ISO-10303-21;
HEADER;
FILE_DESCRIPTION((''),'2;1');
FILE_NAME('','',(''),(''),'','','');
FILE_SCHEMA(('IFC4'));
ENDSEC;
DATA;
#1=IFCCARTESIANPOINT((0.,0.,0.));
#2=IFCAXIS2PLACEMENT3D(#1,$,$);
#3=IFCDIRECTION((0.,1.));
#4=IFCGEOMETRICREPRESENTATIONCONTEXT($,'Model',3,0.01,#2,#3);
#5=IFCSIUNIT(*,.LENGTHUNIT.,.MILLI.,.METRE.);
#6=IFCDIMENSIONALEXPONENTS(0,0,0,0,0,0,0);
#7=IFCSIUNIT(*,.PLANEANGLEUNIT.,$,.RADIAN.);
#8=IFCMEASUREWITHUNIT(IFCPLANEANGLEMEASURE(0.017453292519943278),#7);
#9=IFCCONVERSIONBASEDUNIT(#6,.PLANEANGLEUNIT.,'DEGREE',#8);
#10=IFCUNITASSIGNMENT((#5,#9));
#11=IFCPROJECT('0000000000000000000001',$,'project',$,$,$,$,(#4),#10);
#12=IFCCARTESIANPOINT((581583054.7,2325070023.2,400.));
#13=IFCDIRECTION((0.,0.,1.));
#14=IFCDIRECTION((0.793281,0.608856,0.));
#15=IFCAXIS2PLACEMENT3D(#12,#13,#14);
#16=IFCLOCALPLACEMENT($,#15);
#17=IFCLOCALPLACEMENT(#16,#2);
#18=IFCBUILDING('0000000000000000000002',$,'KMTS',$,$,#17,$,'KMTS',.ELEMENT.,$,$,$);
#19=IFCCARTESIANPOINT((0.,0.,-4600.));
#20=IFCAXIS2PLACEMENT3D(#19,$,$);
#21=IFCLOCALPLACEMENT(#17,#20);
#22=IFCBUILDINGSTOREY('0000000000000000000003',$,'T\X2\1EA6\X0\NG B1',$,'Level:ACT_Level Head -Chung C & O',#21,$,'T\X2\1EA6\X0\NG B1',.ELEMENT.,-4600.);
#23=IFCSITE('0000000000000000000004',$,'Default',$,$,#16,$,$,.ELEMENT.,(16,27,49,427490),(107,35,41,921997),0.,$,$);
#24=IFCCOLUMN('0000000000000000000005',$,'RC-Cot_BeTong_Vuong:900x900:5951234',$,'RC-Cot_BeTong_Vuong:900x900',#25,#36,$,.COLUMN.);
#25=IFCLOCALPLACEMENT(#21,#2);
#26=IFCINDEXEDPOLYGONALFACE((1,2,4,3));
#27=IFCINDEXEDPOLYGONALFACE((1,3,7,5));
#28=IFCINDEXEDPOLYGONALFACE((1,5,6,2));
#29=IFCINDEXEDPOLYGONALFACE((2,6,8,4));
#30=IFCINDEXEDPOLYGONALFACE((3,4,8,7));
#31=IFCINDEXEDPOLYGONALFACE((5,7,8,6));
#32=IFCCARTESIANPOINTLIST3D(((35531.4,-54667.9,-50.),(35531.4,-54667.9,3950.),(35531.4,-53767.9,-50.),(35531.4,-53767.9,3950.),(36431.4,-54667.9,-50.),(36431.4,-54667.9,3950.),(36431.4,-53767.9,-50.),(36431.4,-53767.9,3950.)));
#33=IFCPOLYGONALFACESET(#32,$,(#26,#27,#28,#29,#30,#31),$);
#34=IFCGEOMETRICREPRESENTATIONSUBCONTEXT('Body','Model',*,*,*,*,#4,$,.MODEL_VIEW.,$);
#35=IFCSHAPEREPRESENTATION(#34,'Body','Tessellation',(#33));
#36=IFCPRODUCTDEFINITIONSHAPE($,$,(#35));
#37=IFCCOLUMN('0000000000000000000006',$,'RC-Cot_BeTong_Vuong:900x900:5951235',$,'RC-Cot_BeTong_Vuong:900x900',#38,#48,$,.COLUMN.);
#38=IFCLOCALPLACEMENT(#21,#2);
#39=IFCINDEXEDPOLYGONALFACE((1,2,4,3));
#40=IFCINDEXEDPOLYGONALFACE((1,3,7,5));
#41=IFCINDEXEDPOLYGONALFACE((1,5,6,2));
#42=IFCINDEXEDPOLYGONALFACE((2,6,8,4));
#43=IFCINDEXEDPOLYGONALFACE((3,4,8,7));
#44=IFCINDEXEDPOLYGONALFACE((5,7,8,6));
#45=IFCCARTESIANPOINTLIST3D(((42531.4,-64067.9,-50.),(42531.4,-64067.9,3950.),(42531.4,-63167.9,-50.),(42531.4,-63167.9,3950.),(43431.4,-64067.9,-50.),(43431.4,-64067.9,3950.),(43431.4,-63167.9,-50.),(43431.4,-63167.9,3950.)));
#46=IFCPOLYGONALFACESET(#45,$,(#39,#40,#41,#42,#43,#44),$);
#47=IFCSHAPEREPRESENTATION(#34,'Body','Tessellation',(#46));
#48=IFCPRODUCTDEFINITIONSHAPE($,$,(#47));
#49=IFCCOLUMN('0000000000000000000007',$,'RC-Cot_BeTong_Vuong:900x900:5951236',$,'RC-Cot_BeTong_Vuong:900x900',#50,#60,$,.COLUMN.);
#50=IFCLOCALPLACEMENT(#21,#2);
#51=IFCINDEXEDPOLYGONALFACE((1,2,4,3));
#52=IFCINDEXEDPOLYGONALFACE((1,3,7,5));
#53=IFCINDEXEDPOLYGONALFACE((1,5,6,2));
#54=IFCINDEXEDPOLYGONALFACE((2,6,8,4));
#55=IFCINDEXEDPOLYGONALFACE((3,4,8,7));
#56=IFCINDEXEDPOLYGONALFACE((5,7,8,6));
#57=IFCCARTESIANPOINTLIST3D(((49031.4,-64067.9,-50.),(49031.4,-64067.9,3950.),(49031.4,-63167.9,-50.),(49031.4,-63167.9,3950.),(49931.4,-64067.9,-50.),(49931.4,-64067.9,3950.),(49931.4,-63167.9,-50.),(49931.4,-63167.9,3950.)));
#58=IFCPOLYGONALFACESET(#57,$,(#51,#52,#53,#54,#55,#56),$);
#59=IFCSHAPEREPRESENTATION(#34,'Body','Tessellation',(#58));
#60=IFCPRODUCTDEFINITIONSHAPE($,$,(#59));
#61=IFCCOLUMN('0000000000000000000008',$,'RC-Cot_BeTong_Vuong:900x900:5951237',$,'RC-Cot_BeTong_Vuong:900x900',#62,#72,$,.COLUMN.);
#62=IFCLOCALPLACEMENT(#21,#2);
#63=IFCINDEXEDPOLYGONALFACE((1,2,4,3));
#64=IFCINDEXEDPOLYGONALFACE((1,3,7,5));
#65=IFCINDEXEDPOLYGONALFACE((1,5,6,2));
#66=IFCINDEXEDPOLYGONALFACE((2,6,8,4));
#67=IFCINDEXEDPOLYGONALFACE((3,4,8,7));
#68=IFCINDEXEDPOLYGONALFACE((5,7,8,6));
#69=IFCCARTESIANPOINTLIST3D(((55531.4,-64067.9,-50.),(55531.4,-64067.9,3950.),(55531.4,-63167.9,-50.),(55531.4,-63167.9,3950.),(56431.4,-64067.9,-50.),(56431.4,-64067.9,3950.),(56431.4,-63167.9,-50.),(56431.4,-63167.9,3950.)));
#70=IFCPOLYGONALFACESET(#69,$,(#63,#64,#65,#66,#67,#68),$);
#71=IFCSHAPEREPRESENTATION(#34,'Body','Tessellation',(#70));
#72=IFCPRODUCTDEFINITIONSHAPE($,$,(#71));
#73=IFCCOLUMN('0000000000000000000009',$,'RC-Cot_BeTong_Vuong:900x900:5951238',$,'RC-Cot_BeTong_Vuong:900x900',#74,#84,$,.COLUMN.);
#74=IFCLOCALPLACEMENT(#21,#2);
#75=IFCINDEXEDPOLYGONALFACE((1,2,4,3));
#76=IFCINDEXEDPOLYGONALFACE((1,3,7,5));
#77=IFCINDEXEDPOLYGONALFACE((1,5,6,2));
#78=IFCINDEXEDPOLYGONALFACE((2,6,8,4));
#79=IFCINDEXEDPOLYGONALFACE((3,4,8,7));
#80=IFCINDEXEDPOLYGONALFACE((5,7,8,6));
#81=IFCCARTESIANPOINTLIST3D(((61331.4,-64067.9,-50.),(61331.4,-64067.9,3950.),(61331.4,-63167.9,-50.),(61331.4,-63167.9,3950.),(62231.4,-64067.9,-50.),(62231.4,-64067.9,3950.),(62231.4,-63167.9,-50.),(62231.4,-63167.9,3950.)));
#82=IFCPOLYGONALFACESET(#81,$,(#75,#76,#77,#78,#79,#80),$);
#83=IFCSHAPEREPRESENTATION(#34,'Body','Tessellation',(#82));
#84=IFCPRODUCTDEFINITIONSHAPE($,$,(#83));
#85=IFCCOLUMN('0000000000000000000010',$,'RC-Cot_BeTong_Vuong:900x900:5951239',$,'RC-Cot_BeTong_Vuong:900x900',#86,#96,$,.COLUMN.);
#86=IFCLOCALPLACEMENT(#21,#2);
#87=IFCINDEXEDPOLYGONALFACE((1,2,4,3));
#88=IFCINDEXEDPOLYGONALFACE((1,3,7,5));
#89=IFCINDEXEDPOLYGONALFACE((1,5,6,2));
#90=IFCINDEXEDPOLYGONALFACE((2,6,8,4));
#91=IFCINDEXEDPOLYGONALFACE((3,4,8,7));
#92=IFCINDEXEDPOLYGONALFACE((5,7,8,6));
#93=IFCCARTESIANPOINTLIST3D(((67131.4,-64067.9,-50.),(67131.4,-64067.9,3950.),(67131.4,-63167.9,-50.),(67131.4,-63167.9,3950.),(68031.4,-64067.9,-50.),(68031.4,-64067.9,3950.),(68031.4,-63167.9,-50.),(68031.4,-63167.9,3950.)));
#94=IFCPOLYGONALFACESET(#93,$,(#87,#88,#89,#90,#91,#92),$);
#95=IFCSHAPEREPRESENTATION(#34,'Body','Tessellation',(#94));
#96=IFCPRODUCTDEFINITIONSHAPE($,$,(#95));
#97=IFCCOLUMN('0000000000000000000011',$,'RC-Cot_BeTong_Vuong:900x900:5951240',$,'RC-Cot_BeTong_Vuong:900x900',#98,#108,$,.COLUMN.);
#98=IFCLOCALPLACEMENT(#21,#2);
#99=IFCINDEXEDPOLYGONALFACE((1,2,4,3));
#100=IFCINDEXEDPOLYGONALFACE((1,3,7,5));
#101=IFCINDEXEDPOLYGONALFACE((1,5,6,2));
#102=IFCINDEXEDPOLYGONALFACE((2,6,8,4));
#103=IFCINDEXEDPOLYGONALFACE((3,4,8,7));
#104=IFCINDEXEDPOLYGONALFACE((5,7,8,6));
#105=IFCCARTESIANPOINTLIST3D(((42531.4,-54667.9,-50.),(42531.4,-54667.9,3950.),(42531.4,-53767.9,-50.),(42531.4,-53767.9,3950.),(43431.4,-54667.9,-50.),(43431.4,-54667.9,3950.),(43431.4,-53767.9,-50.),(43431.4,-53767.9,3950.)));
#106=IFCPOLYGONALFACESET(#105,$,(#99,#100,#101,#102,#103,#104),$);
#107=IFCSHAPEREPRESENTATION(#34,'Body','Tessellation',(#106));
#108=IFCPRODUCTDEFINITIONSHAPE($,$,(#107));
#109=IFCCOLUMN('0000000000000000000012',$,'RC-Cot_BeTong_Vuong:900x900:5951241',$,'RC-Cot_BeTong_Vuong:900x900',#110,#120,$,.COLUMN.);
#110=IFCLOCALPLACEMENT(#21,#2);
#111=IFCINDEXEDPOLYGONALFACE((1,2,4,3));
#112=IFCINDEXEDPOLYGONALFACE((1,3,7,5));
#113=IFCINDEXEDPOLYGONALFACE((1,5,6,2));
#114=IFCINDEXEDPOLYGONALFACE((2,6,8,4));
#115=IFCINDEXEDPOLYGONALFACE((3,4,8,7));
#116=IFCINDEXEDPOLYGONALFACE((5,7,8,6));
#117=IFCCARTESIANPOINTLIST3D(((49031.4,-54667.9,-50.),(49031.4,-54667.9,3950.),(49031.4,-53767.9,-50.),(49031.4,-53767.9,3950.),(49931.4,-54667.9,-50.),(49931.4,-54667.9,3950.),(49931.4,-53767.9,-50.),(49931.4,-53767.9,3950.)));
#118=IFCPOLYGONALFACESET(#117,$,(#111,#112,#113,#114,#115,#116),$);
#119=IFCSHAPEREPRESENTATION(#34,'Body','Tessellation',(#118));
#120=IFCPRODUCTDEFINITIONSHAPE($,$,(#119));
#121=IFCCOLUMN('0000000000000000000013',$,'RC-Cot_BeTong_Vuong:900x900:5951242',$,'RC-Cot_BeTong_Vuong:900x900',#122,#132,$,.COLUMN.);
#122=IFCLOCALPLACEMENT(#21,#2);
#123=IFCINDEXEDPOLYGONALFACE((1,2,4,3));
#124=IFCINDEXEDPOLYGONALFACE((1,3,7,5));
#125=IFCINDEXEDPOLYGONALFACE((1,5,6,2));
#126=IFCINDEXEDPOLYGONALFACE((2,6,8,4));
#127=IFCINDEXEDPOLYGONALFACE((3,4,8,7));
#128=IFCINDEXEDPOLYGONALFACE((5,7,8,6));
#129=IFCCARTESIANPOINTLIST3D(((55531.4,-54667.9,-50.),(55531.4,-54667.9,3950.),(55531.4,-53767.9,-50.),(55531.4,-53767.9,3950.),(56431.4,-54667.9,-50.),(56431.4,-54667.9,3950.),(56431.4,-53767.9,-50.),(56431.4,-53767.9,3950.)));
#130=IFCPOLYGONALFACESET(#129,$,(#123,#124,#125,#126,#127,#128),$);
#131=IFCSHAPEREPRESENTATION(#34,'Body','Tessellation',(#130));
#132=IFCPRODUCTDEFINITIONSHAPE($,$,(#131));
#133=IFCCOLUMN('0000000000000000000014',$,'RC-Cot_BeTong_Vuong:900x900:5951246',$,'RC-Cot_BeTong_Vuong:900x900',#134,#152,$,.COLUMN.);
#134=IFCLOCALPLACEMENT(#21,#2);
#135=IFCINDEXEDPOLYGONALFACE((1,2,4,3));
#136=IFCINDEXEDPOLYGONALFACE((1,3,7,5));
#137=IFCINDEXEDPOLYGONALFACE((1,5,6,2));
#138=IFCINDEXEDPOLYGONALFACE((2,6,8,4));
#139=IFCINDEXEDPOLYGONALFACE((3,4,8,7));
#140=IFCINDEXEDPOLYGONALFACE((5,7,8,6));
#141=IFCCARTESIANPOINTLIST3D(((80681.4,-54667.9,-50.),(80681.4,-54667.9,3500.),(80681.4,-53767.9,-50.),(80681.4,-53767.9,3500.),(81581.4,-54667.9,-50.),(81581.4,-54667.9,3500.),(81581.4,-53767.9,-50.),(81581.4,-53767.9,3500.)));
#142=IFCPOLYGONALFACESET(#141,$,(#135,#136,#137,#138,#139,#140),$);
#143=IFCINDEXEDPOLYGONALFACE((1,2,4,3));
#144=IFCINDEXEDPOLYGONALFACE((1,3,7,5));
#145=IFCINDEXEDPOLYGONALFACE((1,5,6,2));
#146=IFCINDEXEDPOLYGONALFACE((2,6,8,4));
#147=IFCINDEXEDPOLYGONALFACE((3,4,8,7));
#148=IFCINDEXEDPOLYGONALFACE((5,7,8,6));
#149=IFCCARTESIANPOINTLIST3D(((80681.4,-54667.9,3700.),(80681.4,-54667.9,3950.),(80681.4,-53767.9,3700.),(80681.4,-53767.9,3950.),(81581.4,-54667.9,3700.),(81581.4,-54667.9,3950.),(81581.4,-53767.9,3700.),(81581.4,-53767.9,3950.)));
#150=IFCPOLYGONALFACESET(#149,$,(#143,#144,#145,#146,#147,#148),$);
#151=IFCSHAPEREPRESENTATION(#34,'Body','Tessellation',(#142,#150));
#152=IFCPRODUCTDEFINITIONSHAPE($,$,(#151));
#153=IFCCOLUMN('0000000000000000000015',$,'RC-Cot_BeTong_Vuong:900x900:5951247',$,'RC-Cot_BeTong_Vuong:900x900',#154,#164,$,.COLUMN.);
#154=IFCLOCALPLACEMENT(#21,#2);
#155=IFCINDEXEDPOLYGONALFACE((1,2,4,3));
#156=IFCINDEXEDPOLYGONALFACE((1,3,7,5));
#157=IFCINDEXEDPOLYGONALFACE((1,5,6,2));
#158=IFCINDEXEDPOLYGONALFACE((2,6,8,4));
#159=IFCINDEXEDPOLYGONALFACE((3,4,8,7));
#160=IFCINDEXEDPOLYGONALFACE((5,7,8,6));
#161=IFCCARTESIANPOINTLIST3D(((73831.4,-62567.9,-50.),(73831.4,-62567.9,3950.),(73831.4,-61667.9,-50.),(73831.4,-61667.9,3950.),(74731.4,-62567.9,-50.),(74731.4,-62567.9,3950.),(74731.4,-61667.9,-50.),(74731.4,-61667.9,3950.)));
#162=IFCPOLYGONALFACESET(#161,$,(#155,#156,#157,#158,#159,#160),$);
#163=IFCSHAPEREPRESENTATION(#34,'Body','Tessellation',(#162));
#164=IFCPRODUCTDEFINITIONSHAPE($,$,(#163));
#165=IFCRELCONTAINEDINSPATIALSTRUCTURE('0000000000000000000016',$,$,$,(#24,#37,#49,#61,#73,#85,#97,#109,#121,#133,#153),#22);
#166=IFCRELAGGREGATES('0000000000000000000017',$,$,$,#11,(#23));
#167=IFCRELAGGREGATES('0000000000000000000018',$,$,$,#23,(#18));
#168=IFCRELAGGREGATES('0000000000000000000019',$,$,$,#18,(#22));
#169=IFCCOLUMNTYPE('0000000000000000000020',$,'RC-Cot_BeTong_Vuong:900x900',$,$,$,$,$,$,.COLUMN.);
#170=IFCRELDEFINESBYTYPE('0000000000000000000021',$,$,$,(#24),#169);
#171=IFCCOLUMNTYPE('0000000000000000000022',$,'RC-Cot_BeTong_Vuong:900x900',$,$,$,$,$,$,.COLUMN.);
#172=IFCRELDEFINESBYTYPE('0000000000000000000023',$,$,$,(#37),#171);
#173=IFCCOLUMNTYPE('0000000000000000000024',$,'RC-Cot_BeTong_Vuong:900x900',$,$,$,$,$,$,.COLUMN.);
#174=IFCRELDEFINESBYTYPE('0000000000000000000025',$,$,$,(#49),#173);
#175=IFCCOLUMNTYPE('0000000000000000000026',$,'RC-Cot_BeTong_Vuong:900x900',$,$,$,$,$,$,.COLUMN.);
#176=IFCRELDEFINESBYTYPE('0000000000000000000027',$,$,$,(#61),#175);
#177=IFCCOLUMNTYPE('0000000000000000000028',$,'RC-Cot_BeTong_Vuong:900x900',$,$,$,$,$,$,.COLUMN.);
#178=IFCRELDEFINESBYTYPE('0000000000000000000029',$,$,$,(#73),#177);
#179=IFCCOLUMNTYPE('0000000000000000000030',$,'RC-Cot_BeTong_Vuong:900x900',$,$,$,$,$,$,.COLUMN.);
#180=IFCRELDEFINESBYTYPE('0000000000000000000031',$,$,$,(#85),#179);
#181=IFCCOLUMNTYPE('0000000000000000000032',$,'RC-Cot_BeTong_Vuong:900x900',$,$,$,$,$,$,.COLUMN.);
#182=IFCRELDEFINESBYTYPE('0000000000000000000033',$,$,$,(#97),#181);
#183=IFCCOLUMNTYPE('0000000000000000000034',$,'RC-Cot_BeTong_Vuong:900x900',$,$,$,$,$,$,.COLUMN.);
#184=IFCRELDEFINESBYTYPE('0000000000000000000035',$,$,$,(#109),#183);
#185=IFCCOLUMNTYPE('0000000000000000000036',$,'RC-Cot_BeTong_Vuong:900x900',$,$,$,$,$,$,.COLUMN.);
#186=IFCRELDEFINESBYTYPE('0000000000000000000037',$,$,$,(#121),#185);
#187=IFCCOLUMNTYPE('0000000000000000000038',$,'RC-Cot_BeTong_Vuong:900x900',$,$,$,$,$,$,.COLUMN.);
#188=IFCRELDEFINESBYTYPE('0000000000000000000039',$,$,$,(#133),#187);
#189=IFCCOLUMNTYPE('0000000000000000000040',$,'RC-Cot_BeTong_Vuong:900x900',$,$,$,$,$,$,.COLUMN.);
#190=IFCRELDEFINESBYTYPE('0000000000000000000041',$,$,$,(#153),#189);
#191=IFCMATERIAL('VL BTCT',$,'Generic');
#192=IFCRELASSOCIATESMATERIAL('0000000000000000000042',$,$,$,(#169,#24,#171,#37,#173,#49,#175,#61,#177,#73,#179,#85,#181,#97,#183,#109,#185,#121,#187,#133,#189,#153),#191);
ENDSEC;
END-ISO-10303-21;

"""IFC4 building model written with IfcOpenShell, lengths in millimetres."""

from ifc_helpers import new_model, entity, si_unit, converted_unit, direction, frame, origin, place, context, subcontext, project, spatial, indexed_curve, outline, extrude, source, transform, mapped, material, type_object, type_shapes, element, save


model = new_model("IFC4")

# Units and contexts
model_context = context("Model", 3, precision=0.01, world=origin(), true_north=direction((0.0, 1.0)))
body_context = subcontext(model_context, "Body", "Model", "MODEL_VIEW")
ifc_project = project(units=[si_unit("LENGTHUNIT", "METRE", prefix="MILLI"), converted_unit("PLANEANGLEUNIT", "DEGREE", entity("IfcPlaneAngleMeasure", 0.017453292519943278), si_unit("PLANEANGLEUNIT", "RADIAN"), dimensions=[0, 0, 0, 0, 0, 0, 0])], contexts=[model_context])

# Site, building, storey
site_placement = place(None, frame((581583054.7, 2325070023.2, 400.0), z_axis=(0.0, 0.0, 1.0), x_axis=(0.793281, 0.608856, 0.0)))
site = spatial("IfcSite", under=ifc_project, at=site_placement, Name="Default", CompositionType="ELEMENT", RefLatitude=(16, 27, 49, 427490), RefLongitude=(107, 35, 41, 921997), RefElevation=0.0)
building_placement = place(site_placement, origin())
building = spatial("IfcBuilding", under=site, at=building_placement, Name="KMTS", LongName="KMTS", CompositionType="ELEMENT")
storey_placement = place(building_placement, frame((0.0, 0.0, -4600.0)))
storey = spatial("IfcBuildingStorey", under=building, at=storey_placement, Name="TẦNG B1", ObjectType="Level:ACT_Level Head -Chung C & O", LongName="TẦNG B1", CompositionType="ELEMENT", Elevation=-4600.0)

# Columns
ifc_material = material(Name="VL BTCT", Category="Generic")
column_type_1 = type_object("IfcColumnType", Name="RC-Cot_BeTong_Vuong:900x900", PredefinedType="COLUMN", material=ifc_material)
shared_shape_1 = source(origin(), body_context, "Body", "SweptSolid", [
    extrude(outline(indexed_curve([(-450.0, -450.0), (450.0, -450.0), (450.0, 450.0), (-450.0, 450.0), (-450.0, -450.0)], self_intersect=False)), frame((35981.4, -54217.9, -4650.0), z_axis=(0.0, 0.0, 1.0), x_axis=(-1.0, 0.0, 0.0)), (0.0, 0.0, 1.0), 4000.0),
])
type_shapes(column_type_1, [shared_shape_1])
column_1_placement = place(storey_placement, frame((0.0, 0.0, 4600.0)))
element("IfcColumn", 1, at=column_1_placement, inside=storey, type_object=column_type_1, material=ifc_material, Name="RC-Cot_BeTong_Vuong:900x900:5951234", ObjectType="RC-Cot_BeTong_Vuong:900x900", PredefinedType="COLUMN", context=body_context, shape_type="MappedRepresentation", body=[
    mapped(shared_shape_1, transform((0.0, 0.0, 0.0), scale=1.0)),
])
column_type_2 = type_object("IfcColumnType", Name="RC-Cot_BeTong_Vuong:900x900", PredefinedType="COLUMN", material=ifc_material)
shared_shape_2 = source(origin(), body_context, "Body", "SweptSolid", [
    extrude(outline(indexed_curve([(-450.0, -450.0), (450.0, -450.0), (450.0, 450.0), (-450.0, 450.0), (-450.0, -450.0)], self_intersect=False)), frame((42981.4, -63617.9, -4650.0), z_axis=(0.0, 0.0, 1.0), x_axis=(-1.0, 0.0, 0.0)), (0.0, 0.0, 1.0), 4000.0),
])
type_shapes(column_type_2, [shared_shape_2])
column_2_placement = place(storey_placement, frame((0.0, 0.0, 4600.0)))
element("IfcColumn", 2, at=column_2_placement, inside=storey, type_object=column_type_2, material=ifc_material, Name="RC-Cot_BeTong_Vuong:900x900:5951235", ObjectType="RC-Cot_BeTong_Vuong:900x900", PredefinedType="COLUMN", context=body_context, shape_type="MappedRepresentation", body=[
    mapped(shared_shape_2, transform((0.0, 0.0, 0.0), scale=1.0)),
])
column_type_3 = type_object("IfcColumnType", Name="RC-Cot_BeTong_Vuong:900x900", PredefinedType="COLUMN", material=ifc_material)
shared_shape_3 = source(origin(), body_context, "Body", "SweptSolid", [
    extrude(outline(indexed_curve([(-450.0, -450.0), (450.0, -450.0), (450.0, 450.0), (-450.0, 450.0), (-450.0, -450.0)], self_intersect=False)), frame((49481.4, -63617.9, -4650.0), z_axis=(0.0, 0.0, 1.0), x_axis=(-1.0, 0.0, 0.0)), (0.0, 0.0, 1.0), 4000.0),
])
type_shapes(column_type_3, [shared_shape_3])
column_3_placement = place(storey_placement, frame((0.0, 0.0, 4600.0)))
element("IfcColumn", 3, at=column_3_placement, inside=storey, type_object=column_type_3, material=ifc_material, Name="RC-Cot_BeTong_Vuong:900x900:5951236", ObjectType="RC-Cot_BeTong_Vuong:900x900", PredefinedType="COLUMN", context=body_context, shape_type="MappedRepresentation", body=[
    mapped(shared_shape_3, transform((0.0, 0.0, 0.0), scale=1.0)),
])
column_type_4 = type_object("IfcColumnType", Name="RC-Cot_BeTong_Vuong:900x900", PredefinedType="COLUMN", material=ifc_material)
shared_shape_4 = source(origin(), body_context, "Body", "SweptSolid", [
    extrude(outline(indexed_curve([(-450.0, -450.0), (450.0, -450.0), (450.0, 450.0), (-450.0, 450.0), (-450.0, -450.0)], self_intersect=False)), frame((55981.4, -63617.9, -4650.0), z_axis=(0.0, 0.0, 1.0), x_axis=(-1.0, 0.0, 0.0)), (0.0, 0.0, 1.0), 4000.0),
])
type_shapes(column_type_4, [shared_shape_4])
column_4_placement = place(storey_placement, frame((0.0, 0.0, 4600.0)))
element("IfcColumn", 4, at=column_4_placement, inside=storey, type_object=column_type_4, material=ifc_material, Name="RC-Cot_BeTong_Vuong:900x900:5951237", ObjectType="RC-Cot_BeTong_Vuong:900x900", PredefinedType="COLUMN", context=body_context, shape_type="MappedRepresentation", body=[
    mapped(shared_shape_4, transform((0.0, 0.0, 0.0), scale=1.0)),
])
column_type_5 = type_object("IfcColumnType", Name="RC-Cot_BeTong_Vuong:900x900", PredefinedType="COLUMN", material=ifc_material)
shared_shape_5 = source(origin(), body_context, "Body", "SweptSolid", [
    extrude(outline(indexed_curve([(-450.0, -450.0), (450.0, -450.0), (450.0, 450.0), (-450.0, 450.0), (-450.0, -450.0)], self_intersect=False)), frame((61781.4, -63617.9, -4650.0), z_axis=(0.0, 0.0, 1.0), x_axis=(-1.0, 0.0, 0.0)), (0.0, 0.0, 1.0), 4000.0),
])
type_shapes(column_type_5, [shared_shape_5])
column_5_placement = place(storey_placement, frame((0.0, 0.0, 4600.0)))
element("IfcColumn", 5, at=column_5_placement, inside=storey, type_object=column_type_5, material=ifc_material, Name="RC-Cot_BeTong_Vuong:900x900:5951238", ObjectType="RC-Cot_BeTong_Vuong:900x900", PredefinedType="COLUMN", context=body_context, shape_type="MappedRepresentation", body=[
    mapped(shared_shape_5, transform((0.0, 0.0, 0.0), scale=1.0)),
])
column_type_6 = type_object("IfcColumnType", Name="RC-Cot_BeTong_Vuong:900x900", PredefinedType="COLUMN", material=ifc_material)
shared_shape_6 = source(origin(), body_context, "Body", "SweptSolid", [
    extrude(outline(indexed_curve([(-450.0, -450.0), (450.0, -450.0), (450.0, 450.0), (-450.0, 450.0), (-450.0, -450.0)], self_intersect=False)), frame((67581.4, -63617.9, -4650.0), z_axis=(0.0, 0.0, 1.0), x_axis=(-1.0, 0.0, 0.0)), (0.0, 0.0, 1.0), 4000.0),
])
type_shapes(column_type_6, [shared_shape_6])
column_6_placement = place(storey_placement, frame((0.0, 0.0, 4600.0)))
element("IfcColumn", 6, at=column_6_placement, inside=storey, type_object=column_type_6, material=ifc_material, Name="RC-Cot_BeTong_Vuong:900x900:5951239", ObjectType="RC-Cot_BeTong_Vuong:900x900", PredefinedType="COLUMN", context=body_context, shape_type="MappedRepresentation", body=[
    mapped(shared_shape_6, transform((0.0, 0.0, 0.0), scale=1.0)),
])
column_type_7 = type_object("IfcColumnType", Name="RC-Cot_BeTong_Vuong:900x900", PredefinedType="COLUMN", material=ifc_material)
shared_shape_7 = source(origin(), body_context, "Body", "SweptSolid", [
    extrude(outline(indexed_curve([(-450.0, -450.0), (450.0, -450.0), (450.0, 450.0), (-450.0, 450.0), (-450.0, -450.0)], self_intersect=False)), frame((42981.4, -54217.9, -4650.0), z_axis=(0.0, 0.0, 1.0), x_axis=(-1.0, 0.0, 0.0)), (0.0, 0.0, 1.0), 4000.0),
])
type_shapes(column_type_7, [shared_shape_7])
column_7_placement = place(storey_placement, frame((0.0, 0.0, 4600.0)))
element("IfcColumn", 7, at=column_7_placement, inside=storey, type_object=column_type_7, material=ifc_material, Name="RC-Cot_BeTong_Vuong:900x900:5951240", ObjectType="RC-Cot_BeTong_Vuong:900x900", PredefinedType="COLUMN", context=body_context, shape_type="MappedRepresentation", body=[
    mapped(shared_shape_7, transform((0.0, 0.0, 0.0), scale=1.0)),
])
column_type_8 = type_object("IfcColumnType", Name="RC-Cot_BeTong_Vuong:900x900", PredefinedType="COLUMN", material=ifc_material)
shared_shape_8 = source(origin(), body_context, "Body", "SweptSolid", [
    extrude(outline(indexed_curve([(-450.0, -450.0), (450.0, -450.0), (450.0, 450.0), (-450.0, 450.0), (-450.0, -450.0)], self_intersect=False)), frame((49481.4, -54217.9, -4650.0), z_axis=(0.0, 0.0, 1.0), x_axis=(-1.0, 0.0, 0.0)), (0.0, 0.0, 1.0), 4000.0),
])
type_shapes(column_type_8, [shared_shape_8])
column_8_placement = place(storey_placement, frame((0.0, 0.0, 4600.0)))
element("IfcColumn", 8, at=column_8_placement, inside=storey, type_object=column_type_8, material=ifc_material, Name="RC-Cot_BeTong_Vuong:900x900:5951241", ObjectType="RC-Cot_BeTong_Vuong:900x900", PredefinedType="COLUMN", context=body_context, shape_type="MappedRepresentation", body=[
    mapped(shared_shape_8, transform((0.0, 0.0, 0.0), scale=1.0)),
])
column_type_9 = type_object("IfcColumnType", Name="RC-Cot_BeTong_Vuong:900x900", PredefinedType="COLUMN", material=ifc_material)
shared_shape_9 = source(origin(), body_context, "Body", "SweptSolid", [
    extrude(outline(indexed_curve([(-450.0, -450.0), (450.0, -450.0), (450.0, 450.0), (-450.0, 450.0), (-450.0, -450.0)], self_intersect=False)), frame((55981.4, -54217.9, -4650.0), z_axis=(0.0, 0.0, 1.0), x_axis=(-1.0, 0.0, 0.0)), (0.0, 0.0, 1.0), 4000.0),
])
type_shapes(column_type_9, [shared_shape_9])
column_9_placement = place(storey_placement, frame((0.0, 0.0, 4600.0)))
element("IfcColumn", 9, at=column_9_placement, inside=storey, type_object=column_type_9, material=ifc_material, Name="RC-Cot_BeTong_Vuong:900x900:5951242", ObjectType="RC-Cot_BeTong_Vuong:900x900", PredefinedType="COLUMN", context=body_context, shape_type="MappedRepresentation", body=[
    mapped(shared_shape_9, transform((0.0, 0.0, 0.0), scale=1.0)),
])
column_type_10 = type_object("IfcColumnType", Name="RC-Cot_BeTong_Vuong:900x900", PredefinedType="COLUMN", material=ifc_material)
shared_shape_10 = source(origin(), body_context, "Body", "SweptSolid", [
    extrude(outline(indexed_curve([(-450.0, -450.0), (450.0, -450.0), (450.0, 450.0), (-450.0, 450.0), (-450.0, -450.0)], self_intersect=False)), frame((81131.4, -54217.9, -4650.0), z_axis=(0.0, 0.0, 1.0), x_axis=(-1.0, 0.0, 0.0)), (0.0, 0.0, 1.0), 3550.0),
    extrude(outline(indexed_curve([(-450.0, -450.0), (450.0, -450.0), (450.0, 450.0), (-450.0, 450.0), (-450.0, -450.0)], self_intersect=False)), frame((81131.4, -54217.9, -900.0), z_axis=(0.0, 0.0, 1.0), x_axis=(-1.0, 0.0, 0.0)), (0.0, 0.0, 1.0), 250.0),
])
type_shapes(column_type_10, [shared_shape_10])
column_10_placement = place(storey_placement, frame((0.0, 0.0, 4600.0)))
element("IfcColumn", 10, at=column_10_placement, inside=storey, type_object=column_type_10, material=ifc_material, Name="RC-Cot_BeTong_Vuong:900x900:5951246", ObjectType="RC-Cot_BeTong_Vuong:900x900", PredefinedType="COLUMN", context=body_context, shape_type="MappedRepresentation", body=[
    mapped(shared_shape_10, transform((0.0, 0.0, 0.0), scale=1.0)),
])
column_type_11 = type_object("IfcColumnType", Name="RC-Cot_BeTong_Vuong:900x900", PredefinedType="COLUMN", material=ifc_material)
shared_shape_11 = source(origin(), body_context, "Body", "SweptSolid", [
    extrude(outline(indexed_curve([(-450.0, -450.0), (450.0, -450.0), (450.0, 450.0), (-450.0, 450.0), (-450.0, -450.0)], self_intersect=False)), frame((74281.4, -62117.9, -4650.0), z_axis=(0.0, 0.0, 1.0), x_axis=(-1.0, 0.0, 0.0)), (0.0, 0.0, 1.0), 4000.0),
])
type_shapes(column_type_11, [shared_shape_11])
column_11_placement = place(storey_placement, frame((0.0, 0.0, 4600.0)))
element("IfcColumn", 11, at=column_11_placement, inside=storey, type_object=column_type_11, material=ifc_material, Name="RC-Cot_BeTong_Vuong:900x900:5951247", ObjectType="RC-Cot_BeTong_Vuong:900x900", PredefinedType="COLUMN", context=body_context, shape_type="MappedRepresentation", body=[
    mapped(shared_shape_11, transform((0.0, 0.0, 0.0), scale=1.0)),
])

save(model, "model.ifc")
